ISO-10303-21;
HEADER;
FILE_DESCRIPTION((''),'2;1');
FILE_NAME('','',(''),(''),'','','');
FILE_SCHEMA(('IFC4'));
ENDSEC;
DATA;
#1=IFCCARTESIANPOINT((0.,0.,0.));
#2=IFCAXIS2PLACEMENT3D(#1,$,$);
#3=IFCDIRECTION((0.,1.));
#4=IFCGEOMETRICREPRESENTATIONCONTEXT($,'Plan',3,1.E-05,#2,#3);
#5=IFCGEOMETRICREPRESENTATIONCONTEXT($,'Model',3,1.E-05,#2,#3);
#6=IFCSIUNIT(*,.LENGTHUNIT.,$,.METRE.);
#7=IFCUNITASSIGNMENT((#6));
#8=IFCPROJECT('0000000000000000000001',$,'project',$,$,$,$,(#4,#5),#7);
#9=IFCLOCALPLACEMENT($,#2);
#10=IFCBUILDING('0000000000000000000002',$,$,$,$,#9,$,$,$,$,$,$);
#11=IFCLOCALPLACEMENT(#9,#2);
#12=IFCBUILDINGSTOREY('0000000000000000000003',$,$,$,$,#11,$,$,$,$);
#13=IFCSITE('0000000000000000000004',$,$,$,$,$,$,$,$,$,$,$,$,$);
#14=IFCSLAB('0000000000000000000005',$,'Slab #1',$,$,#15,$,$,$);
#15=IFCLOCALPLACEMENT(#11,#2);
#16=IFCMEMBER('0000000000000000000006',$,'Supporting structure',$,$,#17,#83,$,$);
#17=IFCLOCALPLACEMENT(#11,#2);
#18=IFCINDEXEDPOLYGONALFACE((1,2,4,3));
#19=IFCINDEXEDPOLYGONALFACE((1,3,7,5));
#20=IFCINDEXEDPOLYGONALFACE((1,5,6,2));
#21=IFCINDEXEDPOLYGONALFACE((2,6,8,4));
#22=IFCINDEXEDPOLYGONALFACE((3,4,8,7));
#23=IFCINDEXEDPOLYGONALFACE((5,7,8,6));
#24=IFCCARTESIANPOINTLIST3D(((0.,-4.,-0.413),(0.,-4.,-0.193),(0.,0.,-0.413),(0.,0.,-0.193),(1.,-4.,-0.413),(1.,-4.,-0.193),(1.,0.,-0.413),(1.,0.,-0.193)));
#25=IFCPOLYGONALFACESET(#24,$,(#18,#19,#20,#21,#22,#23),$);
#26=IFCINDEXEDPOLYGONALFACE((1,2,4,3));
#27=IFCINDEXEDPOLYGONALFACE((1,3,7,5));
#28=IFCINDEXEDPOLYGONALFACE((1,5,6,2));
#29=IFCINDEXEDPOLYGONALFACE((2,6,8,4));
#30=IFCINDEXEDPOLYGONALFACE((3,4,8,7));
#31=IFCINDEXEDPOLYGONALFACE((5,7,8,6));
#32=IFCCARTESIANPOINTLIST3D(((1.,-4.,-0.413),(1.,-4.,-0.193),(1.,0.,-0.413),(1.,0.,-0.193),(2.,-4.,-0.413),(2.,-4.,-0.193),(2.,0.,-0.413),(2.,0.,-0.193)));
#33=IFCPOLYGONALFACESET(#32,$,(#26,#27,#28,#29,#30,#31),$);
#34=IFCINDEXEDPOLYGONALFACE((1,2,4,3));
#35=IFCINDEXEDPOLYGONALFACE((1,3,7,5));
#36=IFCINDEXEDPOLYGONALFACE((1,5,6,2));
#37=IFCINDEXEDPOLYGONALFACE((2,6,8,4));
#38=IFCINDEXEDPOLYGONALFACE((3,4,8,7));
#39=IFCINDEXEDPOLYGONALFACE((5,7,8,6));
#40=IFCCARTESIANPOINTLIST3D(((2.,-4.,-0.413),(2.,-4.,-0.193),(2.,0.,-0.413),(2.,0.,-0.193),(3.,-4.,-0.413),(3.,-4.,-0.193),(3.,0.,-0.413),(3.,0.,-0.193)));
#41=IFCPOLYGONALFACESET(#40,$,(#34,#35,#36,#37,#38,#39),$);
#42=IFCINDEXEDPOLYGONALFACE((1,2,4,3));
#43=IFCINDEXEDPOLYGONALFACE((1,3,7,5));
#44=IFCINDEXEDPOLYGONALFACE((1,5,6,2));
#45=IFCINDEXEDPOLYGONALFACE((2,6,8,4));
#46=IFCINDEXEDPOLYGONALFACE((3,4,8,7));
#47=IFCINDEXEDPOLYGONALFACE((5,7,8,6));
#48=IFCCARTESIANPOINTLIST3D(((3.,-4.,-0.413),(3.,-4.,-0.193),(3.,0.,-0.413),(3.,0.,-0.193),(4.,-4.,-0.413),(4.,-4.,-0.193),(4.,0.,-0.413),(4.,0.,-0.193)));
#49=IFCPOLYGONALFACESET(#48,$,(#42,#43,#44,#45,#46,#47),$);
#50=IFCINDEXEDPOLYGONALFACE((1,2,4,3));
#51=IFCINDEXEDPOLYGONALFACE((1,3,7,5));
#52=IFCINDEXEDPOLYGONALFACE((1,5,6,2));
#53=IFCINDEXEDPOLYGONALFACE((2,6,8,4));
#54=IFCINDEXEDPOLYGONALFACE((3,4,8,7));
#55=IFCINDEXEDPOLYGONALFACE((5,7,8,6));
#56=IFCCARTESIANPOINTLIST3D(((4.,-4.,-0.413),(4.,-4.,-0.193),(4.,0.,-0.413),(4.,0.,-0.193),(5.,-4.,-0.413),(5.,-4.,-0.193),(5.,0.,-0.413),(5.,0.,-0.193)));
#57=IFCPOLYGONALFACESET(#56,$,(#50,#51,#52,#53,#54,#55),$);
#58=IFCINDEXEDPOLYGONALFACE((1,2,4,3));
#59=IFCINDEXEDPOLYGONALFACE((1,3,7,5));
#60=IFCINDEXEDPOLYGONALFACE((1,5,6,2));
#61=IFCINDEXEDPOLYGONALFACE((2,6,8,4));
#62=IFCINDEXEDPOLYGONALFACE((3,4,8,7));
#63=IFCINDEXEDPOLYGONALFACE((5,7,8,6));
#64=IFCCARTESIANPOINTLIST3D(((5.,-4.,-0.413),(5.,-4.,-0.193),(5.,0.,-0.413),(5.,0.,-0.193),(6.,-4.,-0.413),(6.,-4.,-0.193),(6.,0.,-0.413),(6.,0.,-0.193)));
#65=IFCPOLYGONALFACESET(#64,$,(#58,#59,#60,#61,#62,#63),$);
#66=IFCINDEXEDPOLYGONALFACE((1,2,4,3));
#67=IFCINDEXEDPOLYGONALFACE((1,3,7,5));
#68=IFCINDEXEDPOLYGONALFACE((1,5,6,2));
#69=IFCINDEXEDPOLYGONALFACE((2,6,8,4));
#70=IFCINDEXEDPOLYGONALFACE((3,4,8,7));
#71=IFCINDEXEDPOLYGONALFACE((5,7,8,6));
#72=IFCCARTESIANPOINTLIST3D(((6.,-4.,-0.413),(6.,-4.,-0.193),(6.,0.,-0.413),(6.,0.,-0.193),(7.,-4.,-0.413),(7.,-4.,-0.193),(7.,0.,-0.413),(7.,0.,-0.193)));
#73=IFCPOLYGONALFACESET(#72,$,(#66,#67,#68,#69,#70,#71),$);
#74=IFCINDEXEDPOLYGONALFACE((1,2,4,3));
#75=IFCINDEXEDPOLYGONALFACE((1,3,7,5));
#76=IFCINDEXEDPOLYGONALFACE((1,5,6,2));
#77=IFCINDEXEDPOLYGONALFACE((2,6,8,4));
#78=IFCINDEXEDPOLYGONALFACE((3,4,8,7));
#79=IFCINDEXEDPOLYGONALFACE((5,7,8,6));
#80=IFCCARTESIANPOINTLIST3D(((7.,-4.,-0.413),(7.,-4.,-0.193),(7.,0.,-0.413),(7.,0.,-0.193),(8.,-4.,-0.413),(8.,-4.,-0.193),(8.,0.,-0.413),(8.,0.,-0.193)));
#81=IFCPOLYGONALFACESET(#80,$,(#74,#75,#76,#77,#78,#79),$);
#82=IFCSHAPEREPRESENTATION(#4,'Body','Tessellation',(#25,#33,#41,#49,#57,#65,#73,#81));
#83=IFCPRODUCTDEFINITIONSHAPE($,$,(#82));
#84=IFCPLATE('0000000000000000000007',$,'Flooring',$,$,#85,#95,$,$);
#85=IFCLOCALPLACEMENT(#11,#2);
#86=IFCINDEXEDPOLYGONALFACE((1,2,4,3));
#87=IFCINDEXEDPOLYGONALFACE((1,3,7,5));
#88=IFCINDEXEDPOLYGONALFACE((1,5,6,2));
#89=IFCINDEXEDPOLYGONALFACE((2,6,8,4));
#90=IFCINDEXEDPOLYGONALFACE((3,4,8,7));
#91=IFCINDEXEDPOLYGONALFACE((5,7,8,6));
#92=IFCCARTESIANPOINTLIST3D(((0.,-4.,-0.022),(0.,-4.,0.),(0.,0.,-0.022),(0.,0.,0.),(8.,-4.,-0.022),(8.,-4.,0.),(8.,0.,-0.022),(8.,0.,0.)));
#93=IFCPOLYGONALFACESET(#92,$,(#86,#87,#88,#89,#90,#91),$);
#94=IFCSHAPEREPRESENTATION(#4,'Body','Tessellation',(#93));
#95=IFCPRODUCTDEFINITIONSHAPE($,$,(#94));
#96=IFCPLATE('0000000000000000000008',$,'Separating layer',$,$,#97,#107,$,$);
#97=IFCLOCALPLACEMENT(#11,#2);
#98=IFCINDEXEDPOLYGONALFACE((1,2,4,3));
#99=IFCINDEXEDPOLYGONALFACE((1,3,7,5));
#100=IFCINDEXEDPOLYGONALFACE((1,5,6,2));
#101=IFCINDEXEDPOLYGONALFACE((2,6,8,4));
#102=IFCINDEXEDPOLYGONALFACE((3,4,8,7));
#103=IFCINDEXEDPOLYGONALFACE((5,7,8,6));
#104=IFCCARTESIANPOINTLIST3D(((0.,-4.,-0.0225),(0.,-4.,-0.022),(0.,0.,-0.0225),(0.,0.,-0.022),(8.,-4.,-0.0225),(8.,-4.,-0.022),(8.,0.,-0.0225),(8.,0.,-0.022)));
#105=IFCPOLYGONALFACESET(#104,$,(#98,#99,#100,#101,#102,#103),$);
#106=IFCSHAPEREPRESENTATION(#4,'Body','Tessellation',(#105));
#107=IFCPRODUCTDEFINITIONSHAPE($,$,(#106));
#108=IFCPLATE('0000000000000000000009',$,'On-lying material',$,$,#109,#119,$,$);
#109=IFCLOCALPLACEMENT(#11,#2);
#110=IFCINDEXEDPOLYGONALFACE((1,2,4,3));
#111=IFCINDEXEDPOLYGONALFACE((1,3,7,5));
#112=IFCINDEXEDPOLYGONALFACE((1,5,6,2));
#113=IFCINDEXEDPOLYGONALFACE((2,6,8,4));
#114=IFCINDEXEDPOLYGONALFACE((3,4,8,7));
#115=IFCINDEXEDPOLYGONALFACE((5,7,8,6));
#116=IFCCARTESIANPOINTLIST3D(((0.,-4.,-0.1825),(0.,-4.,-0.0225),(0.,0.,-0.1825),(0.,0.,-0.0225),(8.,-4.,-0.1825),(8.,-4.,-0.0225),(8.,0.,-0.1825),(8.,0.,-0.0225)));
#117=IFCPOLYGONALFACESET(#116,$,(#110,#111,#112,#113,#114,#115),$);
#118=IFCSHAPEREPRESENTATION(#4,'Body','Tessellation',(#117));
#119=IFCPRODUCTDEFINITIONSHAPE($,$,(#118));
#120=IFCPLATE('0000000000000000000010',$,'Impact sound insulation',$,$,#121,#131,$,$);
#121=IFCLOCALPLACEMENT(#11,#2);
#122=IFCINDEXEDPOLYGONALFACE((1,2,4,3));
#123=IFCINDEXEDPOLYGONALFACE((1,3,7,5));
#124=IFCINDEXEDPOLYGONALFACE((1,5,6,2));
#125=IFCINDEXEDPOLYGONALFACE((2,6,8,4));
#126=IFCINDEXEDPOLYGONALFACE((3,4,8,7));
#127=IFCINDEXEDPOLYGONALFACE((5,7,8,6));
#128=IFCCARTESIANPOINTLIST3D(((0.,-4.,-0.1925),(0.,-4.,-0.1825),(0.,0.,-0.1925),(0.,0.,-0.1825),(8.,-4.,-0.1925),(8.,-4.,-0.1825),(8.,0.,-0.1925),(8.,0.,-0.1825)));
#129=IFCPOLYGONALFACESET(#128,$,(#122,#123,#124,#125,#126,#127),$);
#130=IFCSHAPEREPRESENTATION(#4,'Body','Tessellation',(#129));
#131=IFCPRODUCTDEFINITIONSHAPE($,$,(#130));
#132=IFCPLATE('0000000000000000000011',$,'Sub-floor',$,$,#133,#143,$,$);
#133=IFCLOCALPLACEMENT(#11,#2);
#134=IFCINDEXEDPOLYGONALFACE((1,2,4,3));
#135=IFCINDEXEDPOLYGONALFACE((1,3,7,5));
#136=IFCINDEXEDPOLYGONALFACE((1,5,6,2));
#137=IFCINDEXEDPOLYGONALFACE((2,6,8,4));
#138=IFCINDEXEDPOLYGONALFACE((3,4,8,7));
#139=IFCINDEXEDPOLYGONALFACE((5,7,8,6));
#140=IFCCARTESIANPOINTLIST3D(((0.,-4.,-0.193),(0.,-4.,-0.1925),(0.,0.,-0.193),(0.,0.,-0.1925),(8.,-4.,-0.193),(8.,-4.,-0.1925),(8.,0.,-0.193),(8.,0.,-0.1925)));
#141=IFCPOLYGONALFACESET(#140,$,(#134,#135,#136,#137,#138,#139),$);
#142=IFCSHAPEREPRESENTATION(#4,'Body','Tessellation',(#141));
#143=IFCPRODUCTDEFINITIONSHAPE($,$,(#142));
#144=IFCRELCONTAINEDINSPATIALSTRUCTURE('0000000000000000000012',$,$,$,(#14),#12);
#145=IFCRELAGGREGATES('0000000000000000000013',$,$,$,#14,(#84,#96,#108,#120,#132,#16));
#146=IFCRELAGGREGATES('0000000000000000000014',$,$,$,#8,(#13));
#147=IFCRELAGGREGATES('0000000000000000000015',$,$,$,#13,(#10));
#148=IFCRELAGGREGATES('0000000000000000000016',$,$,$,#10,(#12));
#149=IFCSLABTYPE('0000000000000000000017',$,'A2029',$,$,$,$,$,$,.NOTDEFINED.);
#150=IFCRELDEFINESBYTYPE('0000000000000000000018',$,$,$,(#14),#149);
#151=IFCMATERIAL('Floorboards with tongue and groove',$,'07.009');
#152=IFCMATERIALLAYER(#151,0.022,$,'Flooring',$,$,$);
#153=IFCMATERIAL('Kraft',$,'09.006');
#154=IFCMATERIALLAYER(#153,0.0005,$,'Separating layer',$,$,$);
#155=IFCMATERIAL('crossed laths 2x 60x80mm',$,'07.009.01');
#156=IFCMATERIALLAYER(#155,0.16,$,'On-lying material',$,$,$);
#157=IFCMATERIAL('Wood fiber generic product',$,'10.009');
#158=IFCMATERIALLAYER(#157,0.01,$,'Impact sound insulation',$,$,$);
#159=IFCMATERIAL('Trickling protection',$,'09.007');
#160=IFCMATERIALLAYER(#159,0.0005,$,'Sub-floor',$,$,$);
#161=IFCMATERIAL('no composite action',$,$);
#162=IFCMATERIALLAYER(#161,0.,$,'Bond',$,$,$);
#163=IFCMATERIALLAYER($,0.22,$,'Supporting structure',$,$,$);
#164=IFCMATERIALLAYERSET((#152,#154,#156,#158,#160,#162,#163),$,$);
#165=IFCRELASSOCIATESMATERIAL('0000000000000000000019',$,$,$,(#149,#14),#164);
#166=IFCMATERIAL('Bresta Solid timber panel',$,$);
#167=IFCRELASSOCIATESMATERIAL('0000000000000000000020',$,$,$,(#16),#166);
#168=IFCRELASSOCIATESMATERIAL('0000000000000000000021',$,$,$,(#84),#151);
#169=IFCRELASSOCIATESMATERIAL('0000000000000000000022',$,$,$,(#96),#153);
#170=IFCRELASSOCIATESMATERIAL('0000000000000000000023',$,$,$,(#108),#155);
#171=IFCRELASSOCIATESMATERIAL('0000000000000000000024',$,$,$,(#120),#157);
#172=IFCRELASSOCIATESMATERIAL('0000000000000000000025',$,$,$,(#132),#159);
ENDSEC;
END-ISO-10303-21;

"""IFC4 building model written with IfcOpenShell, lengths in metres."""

from ifc_helpers import new_model, si_unit, direction, frame, frame_2d, origin, origin_with_axes, place, context, project, spatial, rectangle, extrude, material, layer, layer_set, type_object, element, aggregate, save


model = new_model("IFC4")

# Units and contexts
plan_context = context("Plan", 3, precision=1e-05, world=origin(), true_north=direction((0.0, 1.0)))
model_context = context("Model", 3, precision=1e-05, world=origin(), true_north=direction((0.0, 1.0)))
ifc_project = project(units=[si_unit("LENGTHUNIT", "METRE")], contexts=[plan_context, model_context])

# Site, building, storey
site = spatial("IfcSite", under=ifc_project)
building_placement = place(None, origin())
building = spatial("IfcBuilding", under=site, at=building_placement)
storey_placement = place(building_placement, origin())
storey = spatial("IfcBuildingStorey", under=building, at=storey_placement)

# Slab, member, plates
ifc_material_1 = material(Name="Floorboards with tongue and groove", Category="07.009")
ifc_layer_1 = layer(ifc_material_1, 0.022, Name="Flooring")
ifc_material_2 = material(Name="Kraft", Category="09.006")
ifc_layer_2 = layer(ifc_material_2, 0.0005, Name="Separating layer")
ifc_material_3 = material(Name="crossed laths 2x 60x80mm", Category="07.009.01")
ifc_layer_3 = layer(ifc_material_3, 0.16, Name="On-lying material")
ifc_material_4 = material(Name="Wood fiber generic product", Category="10.009")
ifc_layer_4 = layer(ifc_material_4, 0.01, Name="Impact sound insulation")
ifc_material_5 = material(Name="Trickling protection", Category="09.007")
ifc_layer_5 = layer(ifc_material_5, 0.0005, Name="Sub-floor")
ifc_material_6 = material(Name="no composite action")
ifc_layer_6 = layer(ifc_material_6, 0.0, Name="Bond")
ifc_layer_7 = layer(None, 0.22, Name="Supporting structure")
ifc_layer_set = layer_set([ifc_layer_1, ifc_layer_2, ifc_layer_3, ifc_layer_4, ifc_layer_5, ifc_layer_6, ifc_layer_7])
slab_type = type_object("IfcSlabType", Name="A2029", PredefinedType="NOTDEFINED", material=ifc_layer_set)
slab_placement = place(None, frame((0.0, 0.0, 0.0), z_axis=(0.0, 0.0, -1.0), x_axis=(1.0, 0.0, 0.0)))
slab = element("IfcSlab", 1, at=slab_placement, inside=storey, type_object=slab_type, material=ifc_layer_set, Name="Slab #1")
ifc_material_7 = material(Name="Bresta Solid timber panel")
member_placement = place(slab_placement, origin())
member = element("IfcMember", 2, at=member_placement, material=ifc_material_7, Name="Supporting structure", context=plan_context, shape_type="SweptSolid", body=[
    extrude(rectangle(XDim=1.0, YDim=0.22, at=frame_2d((0.5, 0.11), x_axis=(1.0, 0.0))), frame((0.0, 4.0, 0.193), z_axis=(0.0, -1.0, 0.0), x_axis=(1.0, 0.0, 0.0)), (0.0, 0.0, 1.0), 4.0),
    extrude(rectangle(XDim=1.0, YDim=0.22, at=frame_2d((0.5, 0.11), x_axis=(1.0, 0.0))), frame((1.0, 4.0, 0.193), z_axis=(0.0, -1.0, 0.0), x_axis=(1.0, 0.0, 0.0)), (0.0, 0.0, 1.0), 4.0),
    extrude(rectangle(XDim=1.0, YDim=0.22, at=frame_2d((0.5, 0.11), x_axis=(1.0, 0.0))), frame((2.0, 4.0, 0.193), z_axis=(0.0, -1.0, 0.0), x_axis=(1.0, 0.0, 0.0)), (0.0, 0.0, 1.0), 4.0),
    extrude(rectangle(XDim=1.0, YDim=0.22, at=frame_2d((0.5, 0.11), x_axis=(1.0, 0.0))), frame((3.0, 4.0, 0.193), z_axis=(0.0, -1.0, 0.0), x_axis=(1.0, 0.0, 0.0)), (0.0, 0.0, 1.0), 4.0),
    extrude(rectangle(XDim=1.0, YDim=0.22, at=frame_2d((0.5, 0.11), x_axis=(1.0, 0.0))), frame((4.0, 4.0, 0.193), z_axis=(0.0, -1.0, 0.0), x_axis=(1.0, 0.0, 0.0)), (0.0, 0.0, 1.0), 4.0),
    extrude(rectangle(XDim=1.0, YDim=0.22, at=frame_2d((0.5, 0.11), x_axis=(1.0, 0.0))), frame((5.0, 4.0, 0.193), z_axis=(0.0, -1.0, 0.0), x_axis=(1.0, 0.0, 0.0)), (0.0, 0.0, 1.0), 4.0),
    extrude(rectangle(XDim=1.0, YDim=0.22, at=frame_2d((0.5, 0.11), x_axis=(1.0, 0.0))), frame((6.0, 4.0, 0.193), z_axis=(0.0, -1.0, 0.0), x_axis=(1.0, 0.0, 0.0)), (0.0, 0.0, 1.0), 4.0),
    extrude(rectangle(XDim=1.0, YDim=0.22, at=frame_2d((0.5, 0.11), x_axis=(1.0, 0.0))), frame((7.0, 4.0, 0.193), z_axis=(0.0, -1.0, 0.0), x_axis=(1.0, 0.0, 0.0)), (0.0, 0.0, 1.0), 4.0),
])
plate_1_placement = place(slab_placement, origin())
plate_1 = element("IfcPlate", 3, at=plate_1_placement, material=ifc_material_1, Name="Flooring", context=plan_context, shape_type="SweptSolid", body=[
    extrude(rectangle(XDim=8.0, YDim=4.0, at=frame_2d((4.0, 2.0), x_axis=(1.0, 0.0))), origin_with_axes(), (0.0, 0.0, 1.0), 0.022),
])
plate_2_placement = place(slab_placement, origin())
plate_2 = element("IfcPlate", 4, at=plate_2_placement, material=ifc_material_2, Name="Separating layer", context=plan_context, shape_type="SweptSolid", body=[
    extrude(rectangle(XDim=8.0, YDim=4.0, at=frame_2d((4.0, 2.0), x_axis=(1.0, 0.0))), frame((0.0, 0.0, 0.022), z_axis=(0.0, 0.0, 1.0), x_axis=(1.0, 0.0, 0.0)), (0.0, 0.0, 1.0), 0.0005),
])
plate_3_placement = place(slab_placement, origin())
plate_3 = element("IfcPlate", 5, at=plate_3_placement, material=ifc_material_3, Name="On-lying material", context=plan_context, shape_type="SweptSolid", body=[
    extrude(rectangle(XDim=8.0, YDim=4.0, at=frame_2d((4.0, 2.0), x_axis=(1.0, 0.0))), frame((0.0, 0.0, 0.0225), z_axis=(0.0, 0.0, 1.0), x_axis=(1.0, 0.0, 0.0)), (0.0, 0.0, 1.0), 0.16),
])
plate_4_placement = place(slab_placement, origin())
plate_4 = element("IfcPlate", 6, at=plate_4_placement, material=ifc_material_4, Name="Impact sound insulation", context=plan_context, shape_type="SweptSolid", body=[
    extrude(rectangle(XDim=8.0, YDim=4.0, at=frame_2d((4.0, 2.0), x_axis=(1.0, 0.0))), frame((0.0, 0.0, 0.1825), z_axis=(0.0, 0.0, 1.0), x_axis=(1.0, 0.0, 0.0)), (0.0, 0.0, 1.0), 0.01),
])
plate_5_placement = place(slab_placement, origin())
plate_5 = element("IfcPlate", 7, at=plate_5_placement, material=ifc_material_5, Name="Sub-floor", context=plan_context, shape_type="SweptSolid", body=[
    extrude(rectangle(XDim=8.0, YDim=4.0, at=frame_2d((4.0, 2.0), x_axis=(1.0, 0.0))), frame((0.0, 0.0, 0.1925), z_axis=(0.0, 0.0, 1.0), x_axis=(1.0, 0.0, 0.0)), (0.0, 0.0, 1.0), 0.0005),
])
aggregate(slab, [plate_1, plate_2, plate_3, plate_4, plate_5, member])

save(model, "model.ifc")
